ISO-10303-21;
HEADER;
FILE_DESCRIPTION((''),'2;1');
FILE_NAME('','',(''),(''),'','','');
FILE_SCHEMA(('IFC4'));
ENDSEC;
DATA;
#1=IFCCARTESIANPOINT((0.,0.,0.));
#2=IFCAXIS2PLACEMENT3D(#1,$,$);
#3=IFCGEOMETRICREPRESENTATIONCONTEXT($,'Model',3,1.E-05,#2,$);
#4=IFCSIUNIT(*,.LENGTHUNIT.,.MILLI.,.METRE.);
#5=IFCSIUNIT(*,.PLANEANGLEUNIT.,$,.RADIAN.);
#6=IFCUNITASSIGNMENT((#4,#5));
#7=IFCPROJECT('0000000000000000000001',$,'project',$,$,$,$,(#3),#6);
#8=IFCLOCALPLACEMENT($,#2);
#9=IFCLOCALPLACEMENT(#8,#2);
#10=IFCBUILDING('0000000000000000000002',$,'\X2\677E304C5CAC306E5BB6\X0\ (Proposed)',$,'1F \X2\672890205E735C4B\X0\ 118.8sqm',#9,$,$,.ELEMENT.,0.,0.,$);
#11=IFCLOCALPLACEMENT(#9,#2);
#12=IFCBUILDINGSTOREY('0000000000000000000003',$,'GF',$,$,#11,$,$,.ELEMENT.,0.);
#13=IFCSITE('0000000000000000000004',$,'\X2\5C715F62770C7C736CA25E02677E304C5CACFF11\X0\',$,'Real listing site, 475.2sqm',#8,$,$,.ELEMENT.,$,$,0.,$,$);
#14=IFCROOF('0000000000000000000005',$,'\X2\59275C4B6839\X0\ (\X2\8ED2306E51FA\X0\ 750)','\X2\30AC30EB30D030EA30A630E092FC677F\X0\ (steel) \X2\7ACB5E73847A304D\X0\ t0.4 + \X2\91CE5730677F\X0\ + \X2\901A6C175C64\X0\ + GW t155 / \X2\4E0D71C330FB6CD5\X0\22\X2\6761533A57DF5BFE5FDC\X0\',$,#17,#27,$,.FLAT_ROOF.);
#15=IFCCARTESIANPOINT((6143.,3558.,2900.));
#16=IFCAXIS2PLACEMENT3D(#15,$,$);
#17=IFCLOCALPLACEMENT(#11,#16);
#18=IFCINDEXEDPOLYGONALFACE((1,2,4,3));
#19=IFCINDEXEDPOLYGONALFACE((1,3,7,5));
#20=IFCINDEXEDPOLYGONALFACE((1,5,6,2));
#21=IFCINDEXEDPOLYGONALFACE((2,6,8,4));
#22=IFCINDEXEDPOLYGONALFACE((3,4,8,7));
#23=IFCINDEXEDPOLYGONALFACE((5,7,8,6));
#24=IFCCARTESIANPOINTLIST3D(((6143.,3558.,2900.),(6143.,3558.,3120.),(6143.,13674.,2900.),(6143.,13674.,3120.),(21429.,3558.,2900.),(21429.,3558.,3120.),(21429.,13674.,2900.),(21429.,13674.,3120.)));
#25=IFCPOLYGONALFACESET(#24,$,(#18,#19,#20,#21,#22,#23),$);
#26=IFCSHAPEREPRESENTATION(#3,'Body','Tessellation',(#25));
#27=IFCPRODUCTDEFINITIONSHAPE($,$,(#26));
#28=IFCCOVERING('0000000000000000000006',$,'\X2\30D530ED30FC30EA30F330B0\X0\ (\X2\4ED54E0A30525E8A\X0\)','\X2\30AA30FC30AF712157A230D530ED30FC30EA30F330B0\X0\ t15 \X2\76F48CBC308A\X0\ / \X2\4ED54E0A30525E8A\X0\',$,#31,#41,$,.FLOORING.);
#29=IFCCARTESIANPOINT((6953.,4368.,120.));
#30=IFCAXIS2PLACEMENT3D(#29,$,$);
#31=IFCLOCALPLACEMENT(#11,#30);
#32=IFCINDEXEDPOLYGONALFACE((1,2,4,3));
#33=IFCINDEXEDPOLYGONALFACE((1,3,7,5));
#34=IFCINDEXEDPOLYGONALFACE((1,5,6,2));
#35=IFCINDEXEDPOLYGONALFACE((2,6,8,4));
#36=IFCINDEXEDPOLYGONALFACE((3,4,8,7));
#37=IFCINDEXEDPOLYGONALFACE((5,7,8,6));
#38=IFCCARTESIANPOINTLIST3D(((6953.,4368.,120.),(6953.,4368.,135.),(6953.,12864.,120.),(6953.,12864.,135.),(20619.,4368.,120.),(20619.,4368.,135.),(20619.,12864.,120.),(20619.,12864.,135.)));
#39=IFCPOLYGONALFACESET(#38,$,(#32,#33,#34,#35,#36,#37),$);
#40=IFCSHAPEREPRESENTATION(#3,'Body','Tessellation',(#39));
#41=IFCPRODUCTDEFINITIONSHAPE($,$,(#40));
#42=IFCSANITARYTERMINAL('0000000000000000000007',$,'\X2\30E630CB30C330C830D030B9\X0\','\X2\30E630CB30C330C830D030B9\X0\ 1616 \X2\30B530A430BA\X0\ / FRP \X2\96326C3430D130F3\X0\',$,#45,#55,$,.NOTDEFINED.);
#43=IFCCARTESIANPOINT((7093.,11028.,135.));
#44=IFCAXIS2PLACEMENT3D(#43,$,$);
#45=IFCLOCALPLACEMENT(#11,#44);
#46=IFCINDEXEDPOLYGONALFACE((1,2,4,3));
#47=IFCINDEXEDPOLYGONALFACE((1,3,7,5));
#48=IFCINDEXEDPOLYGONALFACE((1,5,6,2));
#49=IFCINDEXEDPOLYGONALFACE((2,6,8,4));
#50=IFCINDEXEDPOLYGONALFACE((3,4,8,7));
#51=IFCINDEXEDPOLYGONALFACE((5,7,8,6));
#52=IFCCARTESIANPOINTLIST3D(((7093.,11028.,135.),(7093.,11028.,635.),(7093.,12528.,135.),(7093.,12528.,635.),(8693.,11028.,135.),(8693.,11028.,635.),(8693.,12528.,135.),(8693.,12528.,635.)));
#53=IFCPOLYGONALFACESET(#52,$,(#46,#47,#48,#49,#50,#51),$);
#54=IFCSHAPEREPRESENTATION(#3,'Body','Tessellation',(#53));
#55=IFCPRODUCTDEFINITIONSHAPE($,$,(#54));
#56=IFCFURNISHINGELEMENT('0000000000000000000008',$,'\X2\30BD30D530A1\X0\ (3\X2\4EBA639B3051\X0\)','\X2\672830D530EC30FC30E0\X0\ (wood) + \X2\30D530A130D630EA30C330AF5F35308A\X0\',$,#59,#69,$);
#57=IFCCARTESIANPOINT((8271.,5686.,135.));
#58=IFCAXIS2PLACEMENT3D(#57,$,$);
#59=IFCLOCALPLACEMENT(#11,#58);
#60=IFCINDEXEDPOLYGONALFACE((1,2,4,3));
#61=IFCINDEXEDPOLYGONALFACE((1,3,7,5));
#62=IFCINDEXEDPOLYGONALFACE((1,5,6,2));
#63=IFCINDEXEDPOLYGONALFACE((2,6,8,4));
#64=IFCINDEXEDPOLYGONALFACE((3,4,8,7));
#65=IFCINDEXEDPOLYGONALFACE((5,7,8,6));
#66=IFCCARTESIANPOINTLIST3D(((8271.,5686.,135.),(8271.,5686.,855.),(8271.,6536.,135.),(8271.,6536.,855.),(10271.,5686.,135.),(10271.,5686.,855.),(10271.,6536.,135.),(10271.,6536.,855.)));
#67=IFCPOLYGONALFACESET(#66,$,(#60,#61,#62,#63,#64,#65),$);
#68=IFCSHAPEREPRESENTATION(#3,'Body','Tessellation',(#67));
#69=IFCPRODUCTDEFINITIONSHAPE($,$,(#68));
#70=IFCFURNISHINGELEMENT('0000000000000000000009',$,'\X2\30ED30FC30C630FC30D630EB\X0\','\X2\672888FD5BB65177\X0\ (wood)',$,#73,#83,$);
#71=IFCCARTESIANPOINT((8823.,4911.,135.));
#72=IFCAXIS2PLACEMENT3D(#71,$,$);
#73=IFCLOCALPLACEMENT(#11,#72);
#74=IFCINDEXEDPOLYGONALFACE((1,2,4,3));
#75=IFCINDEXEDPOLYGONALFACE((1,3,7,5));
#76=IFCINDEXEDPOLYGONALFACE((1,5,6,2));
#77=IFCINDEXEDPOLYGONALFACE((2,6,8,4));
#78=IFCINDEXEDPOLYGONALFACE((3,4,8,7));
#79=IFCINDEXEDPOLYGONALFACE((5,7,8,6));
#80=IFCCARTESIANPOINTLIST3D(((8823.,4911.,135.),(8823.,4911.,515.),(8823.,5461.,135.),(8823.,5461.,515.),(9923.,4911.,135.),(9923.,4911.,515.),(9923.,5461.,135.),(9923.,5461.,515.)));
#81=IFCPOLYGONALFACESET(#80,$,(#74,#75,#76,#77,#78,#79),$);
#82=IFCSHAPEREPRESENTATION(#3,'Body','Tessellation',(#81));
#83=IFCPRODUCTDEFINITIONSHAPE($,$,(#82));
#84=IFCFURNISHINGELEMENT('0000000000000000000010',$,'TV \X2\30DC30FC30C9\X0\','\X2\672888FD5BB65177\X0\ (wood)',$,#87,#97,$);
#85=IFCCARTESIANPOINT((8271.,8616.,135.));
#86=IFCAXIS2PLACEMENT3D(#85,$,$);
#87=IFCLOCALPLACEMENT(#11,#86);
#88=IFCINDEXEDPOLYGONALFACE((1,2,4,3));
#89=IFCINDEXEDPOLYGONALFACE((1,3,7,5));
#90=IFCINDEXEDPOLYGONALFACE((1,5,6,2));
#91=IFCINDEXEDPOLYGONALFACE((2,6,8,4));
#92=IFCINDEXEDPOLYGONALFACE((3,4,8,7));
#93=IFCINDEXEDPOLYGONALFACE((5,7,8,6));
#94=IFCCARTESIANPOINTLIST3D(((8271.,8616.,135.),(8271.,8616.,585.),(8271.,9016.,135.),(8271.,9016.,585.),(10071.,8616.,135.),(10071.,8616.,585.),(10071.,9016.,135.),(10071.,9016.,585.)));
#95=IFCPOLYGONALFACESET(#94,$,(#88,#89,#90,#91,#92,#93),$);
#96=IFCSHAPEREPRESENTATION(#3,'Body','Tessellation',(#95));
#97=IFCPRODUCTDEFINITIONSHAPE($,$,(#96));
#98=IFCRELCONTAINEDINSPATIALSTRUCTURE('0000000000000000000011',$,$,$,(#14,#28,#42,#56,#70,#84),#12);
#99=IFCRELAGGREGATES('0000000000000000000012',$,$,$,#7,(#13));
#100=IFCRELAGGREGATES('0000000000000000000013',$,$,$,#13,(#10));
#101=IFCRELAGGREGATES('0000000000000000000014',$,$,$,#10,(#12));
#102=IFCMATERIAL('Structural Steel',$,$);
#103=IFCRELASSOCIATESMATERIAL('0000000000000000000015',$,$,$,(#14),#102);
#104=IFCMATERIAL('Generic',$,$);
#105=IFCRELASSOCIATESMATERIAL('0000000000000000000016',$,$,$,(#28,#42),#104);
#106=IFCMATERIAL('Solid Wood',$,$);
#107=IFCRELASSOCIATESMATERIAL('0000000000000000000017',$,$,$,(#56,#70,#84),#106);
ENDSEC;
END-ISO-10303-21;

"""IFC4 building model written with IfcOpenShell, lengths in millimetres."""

from ifc_helpers import new_model, si_unit, frame, frame_2d, origin, place, context, project, spatial, rectangle, extrude, material, element, save


model = new_model("IFC4")

# Units and contexts
model_context = context("Model", 3, precision=1e-05, world=origin())
ifc_project = project(units=[si_unit("LENGTHUNIT", "METRE", prefix="MILLI"), si_unit("PLANEANGLEUNIT", "RADIAN")], contexts=[model_context])

# Site, building, storey
site_placement = place(None, origin())
site = spatial("IfcSite", under=ifc_project, at=site_placement, Name="山形県米沢市松が岬１", ObjectType="Real listing site, 475.2sqm", CompositionType="ELEMENT", RefElevation=0.0)
building_placement = place(site_placement, origin())
building = spatial("IfcBuilding", under=site, at=building_placement, Name="松が岬の家 (Proposed)", ObjectType="1F 木造平屋 118.8sqm", CompositionType="ELEMENT", ElevationOfRefHeight=0.0, ElevationOfTerrain=0.0)
storey_placement = place(building_placement, origin())
storey = spatial("IfcBuildingStorey", under=building, at=storey_placement, Name="GF", CompositionType="ELEMENT", Elevation=0.0)

# Shared definitions
ifc_material_1 = material(Name="Solid Wood")

# Roof
ifc_material_2 = material(Name="Structural Steel")
roof_placement = place(storey_placement, frame((6143.0, 3558.0, 2900.0)))
element("IfcRoof", 1, at=roof_placement, inside=storey, material=ifc_material_2, Name="大屋根 (軒の出 750)", Description="ガルバリウム鋼板 (steel) 立平葺き t0.4 + 野地板 + 通気層 + GW t155 / 不燃・法22条区域対応", PredefinedType="FLAT_ROOF", context=model_context, shape_type="SweptSolid", body=[
    extrude(rectangle(XDim=15286.0, YDim=10116.0, at=frame_2d((7643.0, 5058.0))), frame((6143.0, 3558.0, 2900.0)), (0.0, 0.0, 1.0), 220.0),
])

# Covering
ifc_material_3 = material(Name="Generic")
covering_placement = place(storey_placement, frame((6953.0, 4368.0, 120.0)))
element("IfcCovering", 2, at=covering_placement, inside=storey, material=ifc_material_3, Name="フローリング (仕上げ床)", Description="オーク無垢フローリング t15 直貼り / 仕上げ床", PredefinedType="FLOORING", context=model_context, shape_type="SweptSolid", body=[
    extrude(rectangle(XDim=13666.0, YDim=8496.0, at=frame_2d((6833.0, 4248.0))), frame((6953.0, 4368.0, 120.0)), (0.0, 0.0, 1.0), 15.0),
])

# Sanitary terminal
sanitary_terminal_placement = place(storey_placement, frame((7093.0, 11028.0, 135.0)))
element("IfcSanitaryTerminal", 3, at=sanitary_terminal_placement, inside=storey, material=ifc_material_3, Name="ユニットバス", Description="ユニットバス 1616 サイズ / FRP 防水パン", PredefinedType="NOTDEFINED", context=model_context, shape_type="SweptSolid", body=[
    extrude(rectangle(XDim=1600.0, YDim=1500.0, at=frame_2d((800.0, 750.0))), frame((7093.0, 11028.0, 135.0)), (0.0, 0.0, 1.0), 500.0),
])

# Furnishing elements
furnishing_1_placement = place(storey_placement, frame((8271.0, 5686.0, 135.0)))
element("IfcFurnishingElement", 4, at=furnishing_1_placement, inside=storey, material=ifc_material_1, Name="ソファ (3人掛け)", Description="木フレーム (wood) + ファブリック張り", context=model_context, shape_type="SweptSolid", body=[
    extrude(rectangle(XDim=2000.0, YDim=850.0, at=frame_2d((1000.0, 425.0))), frame((8271.0, 5686.0, 135.0)), (0.0, 0.0, 1.0), 720.0),
])
furnishing_2_placement = place(storey_placement, frame((8823.0, 4911.0, 135.0)))
element("IfcFurnishingElement", 5, at=furnishing_2_placement, inside=storey, material=ifc_material_1, Name="ローテーブル", Description="木製家具 (wood)", context=model_context, shape_type="SweptSolid", body=[
    extrude(rectangle(XDim=1100.0, YDim=550.0, at=frame_2d((550.0, 275.0))), frame((8823.0, 4911.0, 135.0)), (0.0, 0.0, 1.0), 380.0),
])
furnishing_3_placement = place(storey_placement, frame((8271.0, 8616.0, 135.0)))
element("IfcFurnishingElement", 6, at=furnishing_3_placement, inside=storey, material=ifc_material_1, Name="TV ボード", Description="木製家具 (wood)", context=model_context, shape_type="SweptSolid", body=[
    extrude(rectangle(XDim=1800.0, YDim=400.0, at=frame_2d((900.0, 200.0))), frame((8271.0, 8616.0, 135.0)), (0.0, 0.0, 1.0), 450.0),
])

save(model, "model.ifc")
